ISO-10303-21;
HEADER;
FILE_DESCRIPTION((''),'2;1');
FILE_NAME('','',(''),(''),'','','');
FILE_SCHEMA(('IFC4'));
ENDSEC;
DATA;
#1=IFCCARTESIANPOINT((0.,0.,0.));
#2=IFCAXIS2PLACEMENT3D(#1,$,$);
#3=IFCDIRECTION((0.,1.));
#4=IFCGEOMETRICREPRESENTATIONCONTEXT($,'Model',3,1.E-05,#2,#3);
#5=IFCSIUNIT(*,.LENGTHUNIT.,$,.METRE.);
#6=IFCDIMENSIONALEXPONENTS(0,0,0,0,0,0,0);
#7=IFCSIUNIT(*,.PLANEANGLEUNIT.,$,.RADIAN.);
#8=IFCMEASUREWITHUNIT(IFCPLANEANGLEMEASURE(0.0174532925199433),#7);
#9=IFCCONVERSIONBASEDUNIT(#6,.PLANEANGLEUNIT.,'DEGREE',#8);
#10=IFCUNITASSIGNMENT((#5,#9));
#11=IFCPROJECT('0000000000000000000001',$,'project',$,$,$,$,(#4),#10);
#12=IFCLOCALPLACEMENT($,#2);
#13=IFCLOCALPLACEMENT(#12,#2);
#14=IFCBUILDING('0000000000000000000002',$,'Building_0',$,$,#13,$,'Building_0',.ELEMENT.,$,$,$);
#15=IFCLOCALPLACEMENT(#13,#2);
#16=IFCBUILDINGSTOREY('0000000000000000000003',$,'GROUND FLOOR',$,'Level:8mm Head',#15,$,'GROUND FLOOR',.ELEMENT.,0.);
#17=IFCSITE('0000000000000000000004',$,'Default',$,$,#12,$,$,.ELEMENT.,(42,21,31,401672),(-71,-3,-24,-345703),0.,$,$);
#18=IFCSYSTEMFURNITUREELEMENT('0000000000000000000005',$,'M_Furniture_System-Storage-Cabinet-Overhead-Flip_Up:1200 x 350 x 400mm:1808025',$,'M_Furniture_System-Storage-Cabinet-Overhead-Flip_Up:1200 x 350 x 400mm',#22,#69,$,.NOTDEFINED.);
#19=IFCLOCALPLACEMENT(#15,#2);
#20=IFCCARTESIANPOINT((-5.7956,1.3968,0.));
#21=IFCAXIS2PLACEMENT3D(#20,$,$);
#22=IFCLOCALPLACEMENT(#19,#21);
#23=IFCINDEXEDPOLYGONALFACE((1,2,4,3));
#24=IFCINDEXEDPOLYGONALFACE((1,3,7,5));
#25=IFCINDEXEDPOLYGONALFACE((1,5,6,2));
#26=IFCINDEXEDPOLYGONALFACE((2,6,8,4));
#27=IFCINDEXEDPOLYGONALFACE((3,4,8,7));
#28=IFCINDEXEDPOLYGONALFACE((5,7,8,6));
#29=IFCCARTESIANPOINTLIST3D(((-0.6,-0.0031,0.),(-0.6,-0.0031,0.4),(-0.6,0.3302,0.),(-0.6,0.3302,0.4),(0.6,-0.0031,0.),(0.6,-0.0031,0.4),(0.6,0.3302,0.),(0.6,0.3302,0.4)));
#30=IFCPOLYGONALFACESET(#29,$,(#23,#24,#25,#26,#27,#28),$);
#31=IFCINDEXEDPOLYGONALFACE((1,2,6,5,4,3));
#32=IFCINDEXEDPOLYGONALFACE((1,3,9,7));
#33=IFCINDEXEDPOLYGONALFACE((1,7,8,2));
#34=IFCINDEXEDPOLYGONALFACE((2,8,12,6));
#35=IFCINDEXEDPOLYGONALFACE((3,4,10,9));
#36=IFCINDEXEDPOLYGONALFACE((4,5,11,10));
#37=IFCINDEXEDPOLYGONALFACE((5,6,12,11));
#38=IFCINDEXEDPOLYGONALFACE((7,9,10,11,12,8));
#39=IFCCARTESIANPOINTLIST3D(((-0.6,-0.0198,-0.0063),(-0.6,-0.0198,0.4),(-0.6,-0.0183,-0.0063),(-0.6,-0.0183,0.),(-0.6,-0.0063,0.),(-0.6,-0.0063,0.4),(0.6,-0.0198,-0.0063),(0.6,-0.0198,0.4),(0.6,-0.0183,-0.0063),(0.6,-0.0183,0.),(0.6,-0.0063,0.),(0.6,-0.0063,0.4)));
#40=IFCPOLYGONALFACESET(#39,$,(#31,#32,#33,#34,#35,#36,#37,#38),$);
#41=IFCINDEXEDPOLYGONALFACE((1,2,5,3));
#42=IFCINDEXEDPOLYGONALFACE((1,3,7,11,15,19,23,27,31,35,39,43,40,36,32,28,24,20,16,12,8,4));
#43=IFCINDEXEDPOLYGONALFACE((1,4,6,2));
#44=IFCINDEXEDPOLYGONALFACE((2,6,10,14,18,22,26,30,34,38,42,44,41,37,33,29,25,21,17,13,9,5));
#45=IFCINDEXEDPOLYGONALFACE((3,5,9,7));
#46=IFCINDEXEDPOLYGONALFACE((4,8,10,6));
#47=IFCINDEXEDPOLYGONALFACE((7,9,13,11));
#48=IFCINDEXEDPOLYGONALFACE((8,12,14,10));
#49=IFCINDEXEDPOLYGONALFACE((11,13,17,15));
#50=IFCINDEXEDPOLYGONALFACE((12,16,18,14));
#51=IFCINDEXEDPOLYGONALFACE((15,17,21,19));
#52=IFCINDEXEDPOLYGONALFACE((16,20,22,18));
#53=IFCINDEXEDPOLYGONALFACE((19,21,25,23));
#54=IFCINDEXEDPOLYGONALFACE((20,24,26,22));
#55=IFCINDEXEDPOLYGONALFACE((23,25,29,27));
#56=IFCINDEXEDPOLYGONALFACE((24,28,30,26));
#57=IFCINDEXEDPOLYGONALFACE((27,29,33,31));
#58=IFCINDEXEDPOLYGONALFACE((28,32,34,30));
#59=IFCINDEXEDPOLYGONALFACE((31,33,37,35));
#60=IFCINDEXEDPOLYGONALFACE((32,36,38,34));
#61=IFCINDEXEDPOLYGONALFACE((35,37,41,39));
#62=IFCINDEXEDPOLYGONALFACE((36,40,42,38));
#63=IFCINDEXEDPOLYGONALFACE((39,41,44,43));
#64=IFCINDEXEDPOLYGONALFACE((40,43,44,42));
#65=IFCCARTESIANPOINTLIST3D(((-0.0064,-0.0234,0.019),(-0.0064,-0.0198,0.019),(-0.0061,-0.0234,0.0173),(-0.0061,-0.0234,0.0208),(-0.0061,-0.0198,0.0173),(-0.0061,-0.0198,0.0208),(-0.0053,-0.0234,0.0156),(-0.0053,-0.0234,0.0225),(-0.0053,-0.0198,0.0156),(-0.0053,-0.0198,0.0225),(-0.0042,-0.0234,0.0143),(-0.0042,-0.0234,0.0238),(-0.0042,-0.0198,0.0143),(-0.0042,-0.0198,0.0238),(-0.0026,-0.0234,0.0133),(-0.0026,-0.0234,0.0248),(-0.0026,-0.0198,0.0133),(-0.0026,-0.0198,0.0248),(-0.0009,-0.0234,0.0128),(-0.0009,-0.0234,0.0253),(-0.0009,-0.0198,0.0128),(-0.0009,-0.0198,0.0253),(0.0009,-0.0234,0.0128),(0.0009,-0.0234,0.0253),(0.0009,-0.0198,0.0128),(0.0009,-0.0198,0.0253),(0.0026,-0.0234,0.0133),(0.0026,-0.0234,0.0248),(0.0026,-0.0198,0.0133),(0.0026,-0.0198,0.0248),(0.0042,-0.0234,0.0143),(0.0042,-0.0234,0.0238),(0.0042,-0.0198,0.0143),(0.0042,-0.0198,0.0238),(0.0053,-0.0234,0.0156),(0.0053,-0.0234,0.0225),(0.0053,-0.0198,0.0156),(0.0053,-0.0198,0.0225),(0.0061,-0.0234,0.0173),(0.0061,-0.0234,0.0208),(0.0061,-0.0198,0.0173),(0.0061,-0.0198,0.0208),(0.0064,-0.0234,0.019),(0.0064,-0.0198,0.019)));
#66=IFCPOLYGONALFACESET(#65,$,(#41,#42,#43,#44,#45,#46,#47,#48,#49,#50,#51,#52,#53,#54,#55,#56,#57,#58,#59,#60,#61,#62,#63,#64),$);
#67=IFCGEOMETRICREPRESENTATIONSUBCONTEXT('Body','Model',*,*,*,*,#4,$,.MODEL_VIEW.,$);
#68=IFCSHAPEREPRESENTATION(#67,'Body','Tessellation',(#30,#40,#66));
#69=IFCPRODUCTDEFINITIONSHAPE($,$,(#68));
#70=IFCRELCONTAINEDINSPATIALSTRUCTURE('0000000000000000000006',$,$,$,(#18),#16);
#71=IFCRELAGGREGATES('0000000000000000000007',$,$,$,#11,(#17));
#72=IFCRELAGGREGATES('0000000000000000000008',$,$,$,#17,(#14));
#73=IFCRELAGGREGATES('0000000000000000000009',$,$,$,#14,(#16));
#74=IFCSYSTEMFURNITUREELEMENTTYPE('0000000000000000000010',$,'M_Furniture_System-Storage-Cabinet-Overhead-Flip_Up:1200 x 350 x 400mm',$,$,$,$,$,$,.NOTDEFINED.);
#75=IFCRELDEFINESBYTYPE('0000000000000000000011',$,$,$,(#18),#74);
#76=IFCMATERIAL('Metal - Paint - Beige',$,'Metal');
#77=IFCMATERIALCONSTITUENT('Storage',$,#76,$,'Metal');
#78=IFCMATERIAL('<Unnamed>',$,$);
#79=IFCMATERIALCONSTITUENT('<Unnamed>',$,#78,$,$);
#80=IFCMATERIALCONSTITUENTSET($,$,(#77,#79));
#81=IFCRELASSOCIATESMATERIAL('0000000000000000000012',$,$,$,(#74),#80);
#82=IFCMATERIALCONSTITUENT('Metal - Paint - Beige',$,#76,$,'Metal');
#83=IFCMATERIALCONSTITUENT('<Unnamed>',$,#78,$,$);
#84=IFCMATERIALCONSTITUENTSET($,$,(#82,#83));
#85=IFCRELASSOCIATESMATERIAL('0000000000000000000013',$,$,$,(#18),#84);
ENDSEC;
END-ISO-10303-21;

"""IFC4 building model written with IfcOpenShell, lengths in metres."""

from ifc_helpers import new_model, entity, si_unit, converted_unit, direction, frame, origin, place, context, subcontext, project, spatial, arc, indexed_curve, outline, extrude, source, transform, mapped, material, constituent, constituent_set, type_object, type_shapes, element, save


model = new_model("IFC4")

# Units and contexts
model_context = context("Model", 3, precision=1e-05, world=origin(), true_north=direction((0.0, 1.0)))
body_context = subcontext(model_context, "Body", "Model", "MODEL_VIEW")
ifc_project = project(units=[si_unit("LENGTHUNIT", "METRE"), converted_unit("PLANEANGLEUNIT", "DEGREE", entity("IfcPlaneAngleMeasure", 0.0174532925199433), si_unit("PLANEANGLEUNIT", "RADIAN"), dimensions=[0, 0, 0, 0, 0, 0, 0])], contexts=[model_context])

# Site, building, storey
site_placement = place(None, origin())
site = spatial("IfcSite", under=ifc_project, at=site_placement, Name="Default", CompositionType="ELEMENT", RefLatitude=(42, 21, 31, 401672), RefLongitude=(-71, -3, -24, -345703), RefElevation=0.0)
building_placement = place(site_placement, origin())
building = spatial("IfcBuilding", under=site, at=building_placement, Name="Building_0", LongName="Building_0", CompositionType="ELEMENT")
storey_placement = place(building_placement, origin())
storey = spatial("IfcBuildingStorey", under=building, at=storey_placement, Name="GROUND FLOOR", ObjectType="Level:8mm Head", LongName="GROUND FLOOR", CompositionType="ELEMENT", Elevation=0.0)

# System furniture element
placement = place(storey_placement, origin())
ifc_material_1 = material(Name="Metal - Paint - Beige", Category="Metal")
ifc_constituent_1 = constituent(ifc_material_1, Name="Metal - Paint - Beige", Category="Metal")
ifc_material_2 = material(Name="<Unnamed>")
ifc_constituent_2 = constituent(ifc_material_2, Name="<Unnamed>")
ifc_constituent_set_1 = constituent_set(constituents=[ifc_constituent_1, ifc_constituent_2])
ifc_constituent_3 = constituent(ifc_material_1, Name="Storage", Category="Metal")
ifc_constituent_4 = constituent(ifc_material_2, Name="<Unnamed>")
ifc_constituent_set_2 = constituent_set(constituents=[ifc_constituent_3, ifc_constituent_4])
system_furniture_element_type_1 = type_object("IfcSystemFurnitureElementType", Name="M_Furniture_System-Storage-Cabinet-Overhead-Flip_Up:1200 x 350 x 400mm", PredefinedType="NOTDEFINED", material=ifc_constituent_set_2)
shared_shape_1 = source(origin(), body_context, "Body", "SweptSolid", [
    extrude(outline(indexed_curve([(-0.6, -0.1667), (0.6, -0.1667), (0.6, 0.1667), (-0.6, 0.1667), (-0.6, -0.1667)], self_intersect=False)), frame((0.0, 0.1635, 0.0), z_axis=(0.0, 0.0, 1.0), x_axis=(-1.0, 0.0, 0.0)), (0.0, 0.0, 1.0), 0.4),
    extrude(outline(indexed_curve([(-0.0085, -0.2688), (0.005, -0.2688), (0.005, 0.1376), (0.0035, 0.1376), (0.0035, 0.1312), (-0.0085, 0.1312), (-0.0085, -0.2688)], self_intersect=False)), frame((-0.6, -0.0148, 0.1312), z_axis=(1.0, 0.0, 0.0), x_axis=(0.0, -1.0, 0.0)), (0.0, 0.0, 1.0), 1.2),
    extrude(outline(indexed_curve([(-0.0063, 0.0), (0.0, -0.0064), (0.0063, 0.0), (0.0, 0.0063)], segments=[arc(1, 2, 3), arc(3, 4, 1)], self_intersect=False)), frame((0.0, -0.0234, 0.019), z_axis=(0.0, 1.0, 0.0), x_axis=(-1.0, 0.0, 0.0)), (0.0, 0.0, 1.0), 0.0036),
])
type_shapes(system_furniture_element_type_1, [shared_shape_1])
system_furniture_element_1_placement = place(placement, frame((-5.7956, 1.3968, 0.0)))
element("IfcSystemFurnitureElement", 1, at=system_furniture_element_1_placement, inside=storey, type_object=system_furniture_element_type_1, material=ifc_constituent_set_1, Name="M_Furniture_System-Storage-Cabinet-Overhead-Flip_Up:1200 x 350 x 400mm:1808025", ObjectType="M_Furniture_System-Storage-Cabinet-Overhead-Flip_Up:1200 x 350 x 400mm", PredefinedType="NOTDEFINED", context=body_context, shape_type="MappedRepresentation", body=[
    mapped(shared_shape_1, transform((0.0, 0.0, 0.0), scale=1.0)),
])

save(model, "model.ifc")
